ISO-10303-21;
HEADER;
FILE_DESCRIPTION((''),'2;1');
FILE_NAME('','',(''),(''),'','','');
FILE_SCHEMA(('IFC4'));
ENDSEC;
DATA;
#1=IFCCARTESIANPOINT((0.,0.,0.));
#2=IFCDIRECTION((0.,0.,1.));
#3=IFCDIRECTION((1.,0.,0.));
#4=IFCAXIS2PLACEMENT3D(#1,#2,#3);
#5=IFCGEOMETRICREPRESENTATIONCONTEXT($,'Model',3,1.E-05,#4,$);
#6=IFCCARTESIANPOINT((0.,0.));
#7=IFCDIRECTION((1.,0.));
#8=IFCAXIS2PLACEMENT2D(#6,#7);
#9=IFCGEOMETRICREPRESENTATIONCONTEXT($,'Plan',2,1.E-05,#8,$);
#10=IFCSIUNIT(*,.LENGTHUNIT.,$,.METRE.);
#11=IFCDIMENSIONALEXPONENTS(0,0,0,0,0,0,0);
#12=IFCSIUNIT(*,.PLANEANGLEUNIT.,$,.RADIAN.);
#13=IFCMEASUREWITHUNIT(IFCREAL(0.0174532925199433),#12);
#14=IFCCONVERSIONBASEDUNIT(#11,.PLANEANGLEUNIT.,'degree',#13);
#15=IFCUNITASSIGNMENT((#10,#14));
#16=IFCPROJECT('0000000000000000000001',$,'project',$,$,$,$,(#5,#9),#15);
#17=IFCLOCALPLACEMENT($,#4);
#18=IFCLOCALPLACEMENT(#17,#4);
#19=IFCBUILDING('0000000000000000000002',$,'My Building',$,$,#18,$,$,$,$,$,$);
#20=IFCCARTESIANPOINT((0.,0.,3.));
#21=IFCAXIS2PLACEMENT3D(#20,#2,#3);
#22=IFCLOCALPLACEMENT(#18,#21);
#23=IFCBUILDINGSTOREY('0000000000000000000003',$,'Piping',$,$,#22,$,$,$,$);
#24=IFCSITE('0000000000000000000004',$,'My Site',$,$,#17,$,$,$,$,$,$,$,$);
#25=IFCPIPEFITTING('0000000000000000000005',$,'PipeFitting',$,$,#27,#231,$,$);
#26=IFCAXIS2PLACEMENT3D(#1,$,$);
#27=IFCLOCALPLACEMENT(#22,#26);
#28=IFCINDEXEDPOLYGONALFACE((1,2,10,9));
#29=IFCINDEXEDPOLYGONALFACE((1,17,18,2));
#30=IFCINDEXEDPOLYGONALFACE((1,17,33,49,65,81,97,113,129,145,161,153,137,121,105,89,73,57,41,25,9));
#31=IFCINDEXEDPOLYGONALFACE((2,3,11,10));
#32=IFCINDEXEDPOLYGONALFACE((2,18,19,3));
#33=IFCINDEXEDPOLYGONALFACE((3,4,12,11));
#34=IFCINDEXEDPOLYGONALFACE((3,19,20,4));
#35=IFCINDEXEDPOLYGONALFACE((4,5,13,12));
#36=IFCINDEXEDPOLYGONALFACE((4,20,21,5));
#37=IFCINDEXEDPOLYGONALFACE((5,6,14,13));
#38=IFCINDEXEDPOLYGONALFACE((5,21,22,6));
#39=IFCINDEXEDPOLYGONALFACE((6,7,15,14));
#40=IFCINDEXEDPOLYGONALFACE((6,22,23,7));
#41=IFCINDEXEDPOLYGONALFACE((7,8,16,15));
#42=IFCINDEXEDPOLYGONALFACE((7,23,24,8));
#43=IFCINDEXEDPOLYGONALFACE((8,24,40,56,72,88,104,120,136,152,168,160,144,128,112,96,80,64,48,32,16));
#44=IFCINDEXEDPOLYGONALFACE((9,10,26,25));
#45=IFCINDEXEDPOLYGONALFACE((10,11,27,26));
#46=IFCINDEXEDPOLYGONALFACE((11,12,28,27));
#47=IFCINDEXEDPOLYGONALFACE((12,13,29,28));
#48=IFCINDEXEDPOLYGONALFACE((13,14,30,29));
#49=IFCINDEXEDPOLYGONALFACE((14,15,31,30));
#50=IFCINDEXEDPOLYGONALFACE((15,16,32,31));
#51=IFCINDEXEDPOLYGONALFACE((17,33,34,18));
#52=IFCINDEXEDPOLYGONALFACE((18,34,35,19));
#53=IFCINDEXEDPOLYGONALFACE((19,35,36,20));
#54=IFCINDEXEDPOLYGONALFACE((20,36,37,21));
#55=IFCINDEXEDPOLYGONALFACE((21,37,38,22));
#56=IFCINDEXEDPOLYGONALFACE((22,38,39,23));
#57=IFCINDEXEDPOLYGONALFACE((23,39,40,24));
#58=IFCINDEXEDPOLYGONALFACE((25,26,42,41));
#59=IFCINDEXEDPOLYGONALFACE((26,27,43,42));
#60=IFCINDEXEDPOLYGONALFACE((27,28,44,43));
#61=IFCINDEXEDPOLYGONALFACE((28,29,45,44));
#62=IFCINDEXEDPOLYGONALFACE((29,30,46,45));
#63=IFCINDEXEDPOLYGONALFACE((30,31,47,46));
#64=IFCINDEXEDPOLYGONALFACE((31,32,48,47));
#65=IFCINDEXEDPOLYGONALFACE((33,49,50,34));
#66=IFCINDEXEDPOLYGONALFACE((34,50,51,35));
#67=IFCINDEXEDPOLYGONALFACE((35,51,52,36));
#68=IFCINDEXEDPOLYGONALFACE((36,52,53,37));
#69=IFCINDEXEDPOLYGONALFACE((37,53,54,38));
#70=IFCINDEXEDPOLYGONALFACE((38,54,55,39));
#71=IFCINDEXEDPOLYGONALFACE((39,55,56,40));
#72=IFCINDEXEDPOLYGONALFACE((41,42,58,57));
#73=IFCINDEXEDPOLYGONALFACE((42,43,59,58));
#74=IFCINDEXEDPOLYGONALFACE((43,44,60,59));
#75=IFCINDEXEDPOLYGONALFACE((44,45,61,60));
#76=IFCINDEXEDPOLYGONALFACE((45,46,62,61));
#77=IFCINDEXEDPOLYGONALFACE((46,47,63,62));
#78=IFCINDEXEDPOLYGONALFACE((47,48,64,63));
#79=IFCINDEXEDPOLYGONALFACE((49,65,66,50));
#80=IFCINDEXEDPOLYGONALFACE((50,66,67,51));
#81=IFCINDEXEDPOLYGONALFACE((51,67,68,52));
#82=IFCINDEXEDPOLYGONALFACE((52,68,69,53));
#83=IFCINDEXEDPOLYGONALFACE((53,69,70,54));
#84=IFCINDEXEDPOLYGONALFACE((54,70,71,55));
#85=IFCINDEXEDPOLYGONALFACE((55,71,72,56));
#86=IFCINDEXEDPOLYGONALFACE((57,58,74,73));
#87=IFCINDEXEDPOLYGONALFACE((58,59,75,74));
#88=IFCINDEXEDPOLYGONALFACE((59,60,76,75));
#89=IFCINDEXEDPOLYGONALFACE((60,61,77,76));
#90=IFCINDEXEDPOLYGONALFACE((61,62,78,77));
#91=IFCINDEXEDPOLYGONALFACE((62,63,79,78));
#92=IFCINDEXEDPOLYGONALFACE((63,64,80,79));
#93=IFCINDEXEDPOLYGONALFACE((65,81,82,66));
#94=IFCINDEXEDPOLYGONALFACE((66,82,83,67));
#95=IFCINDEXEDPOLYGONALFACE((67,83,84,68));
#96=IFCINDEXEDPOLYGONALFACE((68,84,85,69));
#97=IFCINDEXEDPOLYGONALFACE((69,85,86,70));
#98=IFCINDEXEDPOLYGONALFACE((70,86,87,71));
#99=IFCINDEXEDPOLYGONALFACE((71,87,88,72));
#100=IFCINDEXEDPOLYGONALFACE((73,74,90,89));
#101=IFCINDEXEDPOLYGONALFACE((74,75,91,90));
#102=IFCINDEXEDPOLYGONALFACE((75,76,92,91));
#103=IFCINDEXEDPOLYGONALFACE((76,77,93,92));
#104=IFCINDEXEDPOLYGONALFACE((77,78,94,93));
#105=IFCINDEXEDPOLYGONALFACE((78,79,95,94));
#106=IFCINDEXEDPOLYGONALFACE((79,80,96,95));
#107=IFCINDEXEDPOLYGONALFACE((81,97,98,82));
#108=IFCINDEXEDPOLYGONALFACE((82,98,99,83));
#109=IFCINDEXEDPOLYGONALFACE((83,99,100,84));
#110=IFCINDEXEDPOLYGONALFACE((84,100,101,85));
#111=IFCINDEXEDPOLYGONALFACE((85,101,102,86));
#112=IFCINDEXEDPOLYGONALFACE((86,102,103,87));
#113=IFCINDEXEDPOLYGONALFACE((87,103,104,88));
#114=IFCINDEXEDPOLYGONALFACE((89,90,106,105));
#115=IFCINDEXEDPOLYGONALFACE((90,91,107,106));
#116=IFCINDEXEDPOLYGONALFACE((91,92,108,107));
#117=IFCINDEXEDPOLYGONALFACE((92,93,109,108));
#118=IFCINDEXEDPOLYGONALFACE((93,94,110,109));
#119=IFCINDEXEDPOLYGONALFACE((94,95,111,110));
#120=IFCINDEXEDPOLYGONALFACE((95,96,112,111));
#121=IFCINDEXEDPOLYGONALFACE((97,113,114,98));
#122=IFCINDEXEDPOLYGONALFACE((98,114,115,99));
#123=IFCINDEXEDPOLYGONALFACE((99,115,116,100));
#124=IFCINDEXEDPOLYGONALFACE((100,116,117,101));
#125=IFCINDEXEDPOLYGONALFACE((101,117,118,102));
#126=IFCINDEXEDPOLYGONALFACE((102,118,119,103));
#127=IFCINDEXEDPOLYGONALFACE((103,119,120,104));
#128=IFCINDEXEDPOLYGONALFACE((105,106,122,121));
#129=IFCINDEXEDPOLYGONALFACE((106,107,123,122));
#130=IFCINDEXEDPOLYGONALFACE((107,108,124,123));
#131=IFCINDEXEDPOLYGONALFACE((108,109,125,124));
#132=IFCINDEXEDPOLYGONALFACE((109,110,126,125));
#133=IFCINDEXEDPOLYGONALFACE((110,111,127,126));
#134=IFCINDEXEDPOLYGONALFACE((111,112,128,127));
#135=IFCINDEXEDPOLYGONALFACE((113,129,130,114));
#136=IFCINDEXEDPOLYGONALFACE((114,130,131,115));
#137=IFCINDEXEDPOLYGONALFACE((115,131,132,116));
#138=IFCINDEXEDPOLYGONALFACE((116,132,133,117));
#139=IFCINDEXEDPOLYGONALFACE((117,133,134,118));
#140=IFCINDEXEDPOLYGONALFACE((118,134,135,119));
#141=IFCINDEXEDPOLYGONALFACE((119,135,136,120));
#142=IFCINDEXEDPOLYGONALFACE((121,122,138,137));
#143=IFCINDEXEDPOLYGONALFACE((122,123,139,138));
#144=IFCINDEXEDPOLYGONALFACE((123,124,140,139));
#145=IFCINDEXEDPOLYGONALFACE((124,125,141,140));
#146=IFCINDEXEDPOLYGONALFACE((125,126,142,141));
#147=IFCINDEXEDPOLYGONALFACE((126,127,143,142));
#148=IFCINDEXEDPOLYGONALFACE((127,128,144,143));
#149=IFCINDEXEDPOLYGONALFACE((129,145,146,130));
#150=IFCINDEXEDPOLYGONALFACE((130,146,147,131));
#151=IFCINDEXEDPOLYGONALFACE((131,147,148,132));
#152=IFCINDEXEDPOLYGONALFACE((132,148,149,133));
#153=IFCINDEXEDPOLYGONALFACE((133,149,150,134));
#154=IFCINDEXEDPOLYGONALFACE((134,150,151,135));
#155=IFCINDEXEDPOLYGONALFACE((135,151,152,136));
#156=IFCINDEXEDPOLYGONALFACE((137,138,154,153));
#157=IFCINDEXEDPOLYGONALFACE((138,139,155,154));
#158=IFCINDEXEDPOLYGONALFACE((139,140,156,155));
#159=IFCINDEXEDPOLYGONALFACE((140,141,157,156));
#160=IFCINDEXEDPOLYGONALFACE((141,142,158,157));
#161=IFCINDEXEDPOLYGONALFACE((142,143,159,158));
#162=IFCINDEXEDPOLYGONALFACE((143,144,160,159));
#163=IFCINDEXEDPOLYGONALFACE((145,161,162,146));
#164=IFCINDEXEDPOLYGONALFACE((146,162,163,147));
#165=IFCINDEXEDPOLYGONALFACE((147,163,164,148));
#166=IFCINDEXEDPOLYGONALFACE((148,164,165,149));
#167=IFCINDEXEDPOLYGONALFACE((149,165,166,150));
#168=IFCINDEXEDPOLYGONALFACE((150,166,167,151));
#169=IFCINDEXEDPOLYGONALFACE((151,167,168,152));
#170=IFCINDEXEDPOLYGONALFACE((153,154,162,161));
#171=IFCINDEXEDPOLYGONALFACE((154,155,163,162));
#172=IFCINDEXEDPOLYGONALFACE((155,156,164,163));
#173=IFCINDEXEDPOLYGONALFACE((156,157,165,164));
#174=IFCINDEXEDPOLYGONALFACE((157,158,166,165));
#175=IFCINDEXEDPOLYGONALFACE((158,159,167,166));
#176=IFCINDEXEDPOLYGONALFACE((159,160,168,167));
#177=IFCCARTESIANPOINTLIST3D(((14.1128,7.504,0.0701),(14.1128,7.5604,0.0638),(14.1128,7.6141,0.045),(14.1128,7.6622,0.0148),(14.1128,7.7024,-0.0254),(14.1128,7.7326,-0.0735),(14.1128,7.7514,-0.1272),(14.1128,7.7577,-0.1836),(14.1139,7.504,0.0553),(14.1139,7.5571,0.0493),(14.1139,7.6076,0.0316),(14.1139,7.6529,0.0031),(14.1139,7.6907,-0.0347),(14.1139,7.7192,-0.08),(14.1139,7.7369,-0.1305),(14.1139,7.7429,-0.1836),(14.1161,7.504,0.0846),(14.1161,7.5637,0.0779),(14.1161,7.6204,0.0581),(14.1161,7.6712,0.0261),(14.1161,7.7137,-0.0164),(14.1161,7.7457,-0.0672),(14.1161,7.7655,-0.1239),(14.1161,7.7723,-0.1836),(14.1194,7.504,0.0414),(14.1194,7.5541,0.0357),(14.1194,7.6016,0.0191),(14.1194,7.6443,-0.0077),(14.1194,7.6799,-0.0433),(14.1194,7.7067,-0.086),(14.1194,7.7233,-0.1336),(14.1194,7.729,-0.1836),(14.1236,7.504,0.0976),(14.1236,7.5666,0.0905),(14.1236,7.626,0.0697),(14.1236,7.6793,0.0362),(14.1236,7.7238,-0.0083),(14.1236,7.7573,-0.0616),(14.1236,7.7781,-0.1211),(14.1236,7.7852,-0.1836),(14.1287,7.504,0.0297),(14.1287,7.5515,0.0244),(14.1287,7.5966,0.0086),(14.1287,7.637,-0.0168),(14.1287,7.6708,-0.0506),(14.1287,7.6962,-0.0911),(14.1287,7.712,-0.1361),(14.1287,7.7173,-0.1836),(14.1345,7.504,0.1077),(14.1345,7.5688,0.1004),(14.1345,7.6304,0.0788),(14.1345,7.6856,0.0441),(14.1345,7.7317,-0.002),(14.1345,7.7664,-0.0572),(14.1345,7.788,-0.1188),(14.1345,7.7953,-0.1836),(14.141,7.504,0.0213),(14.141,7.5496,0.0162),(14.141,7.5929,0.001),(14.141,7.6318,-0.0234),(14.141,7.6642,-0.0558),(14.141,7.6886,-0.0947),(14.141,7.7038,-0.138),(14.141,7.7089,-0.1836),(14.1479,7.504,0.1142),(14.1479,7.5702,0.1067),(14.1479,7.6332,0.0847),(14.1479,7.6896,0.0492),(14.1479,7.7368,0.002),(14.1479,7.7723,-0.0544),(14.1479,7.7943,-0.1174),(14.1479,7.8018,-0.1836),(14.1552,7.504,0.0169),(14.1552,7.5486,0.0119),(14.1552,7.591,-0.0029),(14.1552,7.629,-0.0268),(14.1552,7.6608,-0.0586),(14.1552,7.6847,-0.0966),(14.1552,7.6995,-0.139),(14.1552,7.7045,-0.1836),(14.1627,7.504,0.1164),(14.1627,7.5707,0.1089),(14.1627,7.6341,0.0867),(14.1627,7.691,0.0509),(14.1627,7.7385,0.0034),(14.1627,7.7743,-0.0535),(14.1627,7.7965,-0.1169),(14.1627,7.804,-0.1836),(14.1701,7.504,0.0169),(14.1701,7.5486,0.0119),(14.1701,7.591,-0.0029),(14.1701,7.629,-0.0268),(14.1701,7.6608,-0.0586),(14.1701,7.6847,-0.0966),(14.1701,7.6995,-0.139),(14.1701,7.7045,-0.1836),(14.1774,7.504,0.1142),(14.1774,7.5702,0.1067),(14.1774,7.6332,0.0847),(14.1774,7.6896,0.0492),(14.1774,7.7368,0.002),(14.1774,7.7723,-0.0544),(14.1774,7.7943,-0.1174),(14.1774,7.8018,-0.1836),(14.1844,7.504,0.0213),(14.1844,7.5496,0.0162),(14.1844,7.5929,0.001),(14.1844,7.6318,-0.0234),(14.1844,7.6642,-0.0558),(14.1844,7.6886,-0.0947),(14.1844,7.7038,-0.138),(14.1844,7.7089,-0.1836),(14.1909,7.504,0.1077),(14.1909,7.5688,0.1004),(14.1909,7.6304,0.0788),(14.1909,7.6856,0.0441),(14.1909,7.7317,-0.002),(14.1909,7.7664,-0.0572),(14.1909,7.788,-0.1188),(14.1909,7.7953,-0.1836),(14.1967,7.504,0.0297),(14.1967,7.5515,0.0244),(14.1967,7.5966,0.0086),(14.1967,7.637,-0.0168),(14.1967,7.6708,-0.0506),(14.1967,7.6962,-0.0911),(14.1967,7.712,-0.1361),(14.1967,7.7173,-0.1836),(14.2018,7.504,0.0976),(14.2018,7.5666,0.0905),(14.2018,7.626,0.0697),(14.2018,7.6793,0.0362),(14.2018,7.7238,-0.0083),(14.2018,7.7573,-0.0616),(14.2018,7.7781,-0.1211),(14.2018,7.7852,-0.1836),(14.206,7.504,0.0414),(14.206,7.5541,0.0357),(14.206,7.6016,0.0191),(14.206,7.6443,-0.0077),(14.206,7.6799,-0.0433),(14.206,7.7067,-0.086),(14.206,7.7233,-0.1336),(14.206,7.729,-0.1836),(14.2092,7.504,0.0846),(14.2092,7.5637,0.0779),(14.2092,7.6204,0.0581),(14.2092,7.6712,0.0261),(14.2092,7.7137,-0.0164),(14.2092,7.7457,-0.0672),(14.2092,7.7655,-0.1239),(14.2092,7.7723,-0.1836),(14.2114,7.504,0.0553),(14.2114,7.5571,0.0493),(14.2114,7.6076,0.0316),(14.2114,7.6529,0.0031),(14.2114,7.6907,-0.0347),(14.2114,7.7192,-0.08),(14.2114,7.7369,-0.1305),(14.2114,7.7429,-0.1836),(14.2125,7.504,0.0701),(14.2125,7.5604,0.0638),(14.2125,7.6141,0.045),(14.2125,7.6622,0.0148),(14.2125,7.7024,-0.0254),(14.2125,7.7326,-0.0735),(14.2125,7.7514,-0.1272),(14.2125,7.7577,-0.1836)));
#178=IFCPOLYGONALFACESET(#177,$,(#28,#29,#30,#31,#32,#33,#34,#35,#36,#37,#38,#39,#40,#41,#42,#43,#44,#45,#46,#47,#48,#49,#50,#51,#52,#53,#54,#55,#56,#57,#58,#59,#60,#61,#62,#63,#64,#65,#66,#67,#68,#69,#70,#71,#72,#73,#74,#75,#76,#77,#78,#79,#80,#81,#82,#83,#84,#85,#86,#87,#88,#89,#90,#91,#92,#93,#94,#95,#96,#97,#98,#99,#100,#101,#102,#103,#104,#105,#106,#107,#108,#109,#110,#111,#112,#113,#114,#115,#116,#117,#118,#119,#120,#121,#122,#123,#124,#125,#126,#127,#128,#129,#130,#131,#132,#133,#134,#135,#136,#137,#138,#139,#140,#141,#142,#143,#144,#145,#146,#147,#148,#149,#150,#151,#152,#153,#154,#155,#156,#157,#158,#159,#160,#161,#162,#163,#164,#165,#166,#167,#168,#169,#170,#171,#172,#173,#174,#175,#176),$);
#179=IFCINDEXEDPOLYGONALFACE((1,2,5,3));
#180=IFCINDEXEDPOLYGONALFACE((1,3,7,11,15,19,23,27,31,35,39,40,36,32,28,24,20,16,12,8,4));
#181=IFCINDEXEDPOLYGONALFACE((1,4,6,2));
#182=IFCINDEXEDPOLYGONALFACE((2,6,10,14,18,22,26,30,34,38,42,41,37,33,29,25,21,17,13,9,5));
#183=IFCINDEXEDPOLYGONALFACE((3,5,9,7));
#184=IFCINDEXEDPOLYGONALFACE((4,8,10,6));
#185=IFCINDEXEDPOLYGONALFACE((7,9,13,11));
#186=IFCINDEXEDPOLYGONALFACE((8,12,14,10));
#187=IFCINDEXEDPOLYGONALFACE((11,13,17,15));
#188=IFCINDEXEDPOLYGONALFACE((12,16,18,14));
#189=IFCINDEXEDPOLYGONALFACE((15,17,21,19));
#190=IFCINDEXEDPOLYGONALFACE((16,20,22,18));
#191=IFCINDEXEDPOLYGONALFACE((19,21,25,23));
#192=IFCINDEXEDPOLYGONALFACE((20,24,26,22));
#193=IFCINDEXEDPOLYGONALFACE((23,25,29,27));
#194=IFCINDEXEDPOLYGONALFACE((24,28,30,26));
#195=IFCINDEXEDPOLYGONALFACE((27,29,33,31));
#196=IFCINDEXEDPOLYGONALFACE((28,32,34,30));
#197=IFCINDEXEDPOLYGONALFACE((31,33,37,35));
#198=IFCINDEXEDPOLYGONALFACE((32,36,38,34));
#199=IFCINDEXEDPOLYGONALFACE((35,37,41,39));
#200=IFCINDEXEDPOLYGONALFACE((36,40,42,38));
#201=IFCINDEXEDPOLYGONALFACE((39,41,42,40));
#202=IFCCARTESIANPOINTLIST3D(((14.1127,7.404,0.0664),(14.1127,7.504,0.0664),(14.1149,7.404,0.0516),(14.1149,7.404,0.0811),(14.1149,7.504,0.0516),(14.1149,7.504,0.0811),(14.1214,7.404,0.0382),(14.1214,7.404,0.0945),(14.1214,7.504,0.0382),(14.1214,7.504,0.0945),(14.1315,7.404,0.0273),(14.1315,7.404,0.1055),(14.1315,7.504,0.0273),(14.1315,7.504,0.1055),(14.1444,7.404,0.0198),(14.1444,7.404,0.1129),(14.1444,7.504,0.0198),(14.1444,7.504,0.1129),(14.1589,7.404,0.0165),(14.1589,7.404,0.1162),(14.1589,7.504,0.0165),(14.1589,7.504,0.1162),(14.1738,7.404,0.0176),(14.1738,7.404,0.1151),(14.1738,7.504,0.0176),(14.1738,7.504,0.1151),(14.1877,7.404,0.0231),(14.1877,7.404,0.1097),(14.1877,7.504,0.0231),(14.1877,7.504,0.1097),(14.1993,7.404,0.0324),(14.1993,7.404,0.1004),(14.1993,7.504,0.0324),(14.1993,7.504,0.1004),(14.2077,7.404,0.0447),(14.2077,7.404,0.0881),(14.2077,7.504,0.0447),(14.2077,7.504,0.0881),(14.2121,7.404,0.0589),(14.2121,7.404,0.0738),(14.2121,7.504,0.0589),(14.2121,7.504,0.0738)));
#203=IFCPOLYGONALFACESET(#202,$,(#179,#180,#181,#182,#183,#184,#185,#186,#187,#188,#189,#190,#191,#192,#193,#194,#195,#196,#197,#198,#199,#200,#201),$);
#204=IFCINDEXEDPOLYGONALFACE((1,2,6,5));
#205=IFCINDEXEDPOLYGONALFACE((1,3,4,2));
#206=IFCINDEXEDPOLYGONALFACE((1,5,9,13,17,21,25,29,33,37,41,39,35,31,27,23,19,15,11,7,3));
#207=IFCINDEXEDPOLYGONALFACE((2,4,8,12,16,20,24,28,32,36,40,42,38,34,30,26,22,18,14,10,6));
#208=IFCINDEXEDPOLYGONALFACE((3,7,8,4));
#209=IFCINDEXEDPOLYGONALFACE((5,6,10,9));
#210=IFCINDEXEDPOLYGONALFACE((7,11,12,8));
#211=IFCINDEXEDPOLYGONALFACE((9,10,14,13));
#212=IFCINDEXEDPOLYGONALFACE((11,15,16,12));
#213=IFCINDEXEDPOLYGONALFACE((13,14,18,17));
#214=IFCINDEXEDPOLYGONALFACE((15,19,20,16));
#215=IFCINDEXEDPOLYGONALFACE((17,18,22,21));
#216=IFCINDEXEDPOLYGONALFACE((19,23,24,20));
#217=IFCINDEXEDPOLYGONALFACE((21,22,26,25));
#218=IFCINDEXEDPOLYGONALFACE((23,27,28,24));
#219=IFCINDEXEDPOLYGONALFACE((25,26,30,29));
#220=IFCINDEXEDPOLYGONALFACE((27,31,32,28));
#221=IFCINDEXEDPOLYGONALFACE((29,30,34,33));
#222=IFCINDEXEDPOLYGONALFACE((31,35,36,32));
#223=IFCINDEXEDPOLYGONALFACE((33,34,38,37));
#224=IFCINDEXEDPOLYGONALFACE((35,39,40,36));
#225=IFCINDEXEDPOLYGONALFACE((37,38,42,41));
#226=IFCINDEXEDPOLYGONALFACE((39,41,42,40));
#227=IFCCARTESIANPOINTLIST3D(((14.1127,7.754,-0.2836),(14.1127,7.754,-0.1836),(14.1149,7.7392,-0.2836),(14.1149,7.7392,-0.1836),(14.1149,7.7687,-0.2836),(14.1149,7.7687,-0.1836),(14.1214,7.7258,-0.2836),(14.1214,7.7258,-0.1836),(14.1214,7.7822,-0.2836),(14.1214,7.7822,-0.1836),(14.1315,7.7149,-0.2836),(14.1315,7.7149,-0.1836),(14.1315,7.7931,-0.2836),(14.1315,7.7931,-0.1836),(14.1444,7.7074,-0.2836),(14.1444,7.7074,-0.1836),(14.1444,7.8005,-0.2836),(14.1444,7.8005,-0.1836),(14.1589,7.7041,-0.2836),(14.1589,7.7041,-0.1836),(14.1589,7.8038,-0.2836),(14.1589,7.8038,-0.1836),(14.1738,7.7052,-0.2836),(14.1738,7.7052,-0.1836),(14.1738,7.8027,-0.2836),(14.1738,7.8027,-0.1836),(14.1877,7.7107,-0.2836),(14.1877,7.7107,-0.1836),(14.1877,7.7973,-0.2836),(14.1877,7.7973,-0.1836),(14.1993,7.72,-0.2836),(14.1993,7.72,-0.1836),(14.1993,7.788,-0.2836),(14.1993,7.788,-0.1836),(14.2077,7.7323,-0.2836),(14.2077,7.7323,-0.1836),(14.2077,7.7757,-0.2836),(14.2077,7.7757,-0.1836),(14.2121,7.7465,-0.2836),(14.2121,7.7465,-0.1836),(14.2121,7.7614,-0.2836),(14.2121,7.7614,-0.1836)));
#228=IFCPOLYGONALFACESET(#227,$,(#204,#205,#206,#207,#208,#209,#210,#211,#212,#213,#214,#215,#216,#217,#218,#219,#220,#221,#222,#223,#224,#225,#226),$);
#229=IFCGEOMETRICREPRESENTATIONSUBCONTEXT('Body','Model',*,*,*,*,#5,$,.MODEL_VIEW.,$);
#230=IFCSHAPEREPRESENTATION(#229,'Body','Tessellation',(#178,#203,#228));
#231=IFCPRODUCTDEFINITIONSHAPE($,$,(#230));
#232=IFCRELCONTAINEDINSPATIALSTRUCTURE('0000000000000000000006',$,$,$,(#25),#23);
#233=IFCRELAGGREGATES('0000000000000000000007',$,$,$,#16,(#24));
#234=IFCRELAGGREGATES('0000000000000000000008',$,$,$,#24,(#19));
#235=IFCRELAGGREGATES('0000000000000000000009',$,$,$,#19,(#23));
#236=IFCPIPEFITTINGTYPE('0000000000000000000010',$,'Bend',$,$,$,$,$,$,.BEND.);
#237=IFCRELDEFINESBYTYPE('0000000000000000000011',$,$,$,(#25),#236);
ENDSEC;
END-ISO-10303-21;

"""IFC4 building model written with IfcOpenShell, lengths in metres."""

from ifc_helpers import new_model, entity, si_unit, converted_unit, frame, origin_with_axes, origin_2d_with_axis, place, context, subcontext, project, spatial, circle, extrude, source, transform, mapped, type_object, type_shapes, element, save


model = new_model("IFC4")

# Units and contexts
model_context = context("Model", 3, precision=1e-05, world=origin_with_axes())
plan_context = context("Plan", 2, precision=1e-05, world=origin_2d_with_axis())
body_context = subcontext(model_context, "Body", "Model", "MODEL_VIEW")
ifc_project = project(units=[si_unit("LENGTHUNIT", "METRE"), converted_unit("PLANEANGLEUNIT", "degree", entity("IfcReal", 0.0174532925199433), si_unit("PLANEANGLEUNIT", "RADIAN"), dimensions=[0, 0, 0, 0, 0, 0, 0])], contexts=[model_context, plan_context])

# Site, building, storey
site_placement = place(None, origin_with_axes())
site = spatial("IfcSite", under=ifc_project, at=site_placement, Name="My Site")
building_placement = place(site_placement, origin_with_axes())
building = spatial("IfcBuilding", under=site, at=building_placement, Name="My Building")
storey_placement = place(building_placement, frame((0.0, 0.0, 3.0), z_axis=(0.0, 0.0, 1.0), x_axis=(1.0, 0.0, 0.0)))
storey = spatial("IfcBuildingStorey", under=building, at=storey_placement, Name="Piping")

# Pipe fitting
pipe_fitting_type_1 = type_object("IfcPipeFittingType", Name="Bend", PredefinedType="BEND")
shared_shape = source(origin_with_axes(), body_context, "Body", "SolidModel", [
    entity("IfcSweptDiskSolid", entity("IfcIndexedPolyCurve", entity("IfcCartesianPointList3D", [[0.0, 0.0, 0.1], [0.0, -0.0732, 0.2768], [0.0, -0.25, 0.35]]), [entity("IfcArcIndex", [1, 2, 3])]), 0.05),
    extrude(circle(Radius=0.05), origin_with_axes(), (0.0, 0.0, 1.0), 0.1),
    extrude(circle(Radius=0.05), frame((0.0, -0.25, 0.35), z_axis=(0.0, -1.0, -0.000002), x_axis=(1.0, 0.0, 0.0)), (0.0, 0.0, 1.0), 0.1),
])
type_shapes(pipe_fitting_type_1, [shared_shape])
for number, where, z_axis, x_axis, name in (
    (1, (14.1627, 7.404, 0.0664), (0.0, 1.0, 0.000002), (-1.0, 0.0, 0.0), "PipeFitting"),
):
    element("IfcPipeFitting", number, at=place(storey_placement, frame(where, z_axis=z_axis, x_axis=x_axis)), inside=storey, type_object=pipe_fitting_type_1, Name=name, context=body_context, shape_type="MappedRepresentation", body=[
        mapped(shared_shape, transform((0.0, 0.0, 0.0), x_axis=(1.0, 0.0, 0.0), y_axis=(0.0, 1.0, 0.0), z_axis=(0.0, 0.0, 1.0), scale=1.0)),
    ])

save(model, "model.ifc")
